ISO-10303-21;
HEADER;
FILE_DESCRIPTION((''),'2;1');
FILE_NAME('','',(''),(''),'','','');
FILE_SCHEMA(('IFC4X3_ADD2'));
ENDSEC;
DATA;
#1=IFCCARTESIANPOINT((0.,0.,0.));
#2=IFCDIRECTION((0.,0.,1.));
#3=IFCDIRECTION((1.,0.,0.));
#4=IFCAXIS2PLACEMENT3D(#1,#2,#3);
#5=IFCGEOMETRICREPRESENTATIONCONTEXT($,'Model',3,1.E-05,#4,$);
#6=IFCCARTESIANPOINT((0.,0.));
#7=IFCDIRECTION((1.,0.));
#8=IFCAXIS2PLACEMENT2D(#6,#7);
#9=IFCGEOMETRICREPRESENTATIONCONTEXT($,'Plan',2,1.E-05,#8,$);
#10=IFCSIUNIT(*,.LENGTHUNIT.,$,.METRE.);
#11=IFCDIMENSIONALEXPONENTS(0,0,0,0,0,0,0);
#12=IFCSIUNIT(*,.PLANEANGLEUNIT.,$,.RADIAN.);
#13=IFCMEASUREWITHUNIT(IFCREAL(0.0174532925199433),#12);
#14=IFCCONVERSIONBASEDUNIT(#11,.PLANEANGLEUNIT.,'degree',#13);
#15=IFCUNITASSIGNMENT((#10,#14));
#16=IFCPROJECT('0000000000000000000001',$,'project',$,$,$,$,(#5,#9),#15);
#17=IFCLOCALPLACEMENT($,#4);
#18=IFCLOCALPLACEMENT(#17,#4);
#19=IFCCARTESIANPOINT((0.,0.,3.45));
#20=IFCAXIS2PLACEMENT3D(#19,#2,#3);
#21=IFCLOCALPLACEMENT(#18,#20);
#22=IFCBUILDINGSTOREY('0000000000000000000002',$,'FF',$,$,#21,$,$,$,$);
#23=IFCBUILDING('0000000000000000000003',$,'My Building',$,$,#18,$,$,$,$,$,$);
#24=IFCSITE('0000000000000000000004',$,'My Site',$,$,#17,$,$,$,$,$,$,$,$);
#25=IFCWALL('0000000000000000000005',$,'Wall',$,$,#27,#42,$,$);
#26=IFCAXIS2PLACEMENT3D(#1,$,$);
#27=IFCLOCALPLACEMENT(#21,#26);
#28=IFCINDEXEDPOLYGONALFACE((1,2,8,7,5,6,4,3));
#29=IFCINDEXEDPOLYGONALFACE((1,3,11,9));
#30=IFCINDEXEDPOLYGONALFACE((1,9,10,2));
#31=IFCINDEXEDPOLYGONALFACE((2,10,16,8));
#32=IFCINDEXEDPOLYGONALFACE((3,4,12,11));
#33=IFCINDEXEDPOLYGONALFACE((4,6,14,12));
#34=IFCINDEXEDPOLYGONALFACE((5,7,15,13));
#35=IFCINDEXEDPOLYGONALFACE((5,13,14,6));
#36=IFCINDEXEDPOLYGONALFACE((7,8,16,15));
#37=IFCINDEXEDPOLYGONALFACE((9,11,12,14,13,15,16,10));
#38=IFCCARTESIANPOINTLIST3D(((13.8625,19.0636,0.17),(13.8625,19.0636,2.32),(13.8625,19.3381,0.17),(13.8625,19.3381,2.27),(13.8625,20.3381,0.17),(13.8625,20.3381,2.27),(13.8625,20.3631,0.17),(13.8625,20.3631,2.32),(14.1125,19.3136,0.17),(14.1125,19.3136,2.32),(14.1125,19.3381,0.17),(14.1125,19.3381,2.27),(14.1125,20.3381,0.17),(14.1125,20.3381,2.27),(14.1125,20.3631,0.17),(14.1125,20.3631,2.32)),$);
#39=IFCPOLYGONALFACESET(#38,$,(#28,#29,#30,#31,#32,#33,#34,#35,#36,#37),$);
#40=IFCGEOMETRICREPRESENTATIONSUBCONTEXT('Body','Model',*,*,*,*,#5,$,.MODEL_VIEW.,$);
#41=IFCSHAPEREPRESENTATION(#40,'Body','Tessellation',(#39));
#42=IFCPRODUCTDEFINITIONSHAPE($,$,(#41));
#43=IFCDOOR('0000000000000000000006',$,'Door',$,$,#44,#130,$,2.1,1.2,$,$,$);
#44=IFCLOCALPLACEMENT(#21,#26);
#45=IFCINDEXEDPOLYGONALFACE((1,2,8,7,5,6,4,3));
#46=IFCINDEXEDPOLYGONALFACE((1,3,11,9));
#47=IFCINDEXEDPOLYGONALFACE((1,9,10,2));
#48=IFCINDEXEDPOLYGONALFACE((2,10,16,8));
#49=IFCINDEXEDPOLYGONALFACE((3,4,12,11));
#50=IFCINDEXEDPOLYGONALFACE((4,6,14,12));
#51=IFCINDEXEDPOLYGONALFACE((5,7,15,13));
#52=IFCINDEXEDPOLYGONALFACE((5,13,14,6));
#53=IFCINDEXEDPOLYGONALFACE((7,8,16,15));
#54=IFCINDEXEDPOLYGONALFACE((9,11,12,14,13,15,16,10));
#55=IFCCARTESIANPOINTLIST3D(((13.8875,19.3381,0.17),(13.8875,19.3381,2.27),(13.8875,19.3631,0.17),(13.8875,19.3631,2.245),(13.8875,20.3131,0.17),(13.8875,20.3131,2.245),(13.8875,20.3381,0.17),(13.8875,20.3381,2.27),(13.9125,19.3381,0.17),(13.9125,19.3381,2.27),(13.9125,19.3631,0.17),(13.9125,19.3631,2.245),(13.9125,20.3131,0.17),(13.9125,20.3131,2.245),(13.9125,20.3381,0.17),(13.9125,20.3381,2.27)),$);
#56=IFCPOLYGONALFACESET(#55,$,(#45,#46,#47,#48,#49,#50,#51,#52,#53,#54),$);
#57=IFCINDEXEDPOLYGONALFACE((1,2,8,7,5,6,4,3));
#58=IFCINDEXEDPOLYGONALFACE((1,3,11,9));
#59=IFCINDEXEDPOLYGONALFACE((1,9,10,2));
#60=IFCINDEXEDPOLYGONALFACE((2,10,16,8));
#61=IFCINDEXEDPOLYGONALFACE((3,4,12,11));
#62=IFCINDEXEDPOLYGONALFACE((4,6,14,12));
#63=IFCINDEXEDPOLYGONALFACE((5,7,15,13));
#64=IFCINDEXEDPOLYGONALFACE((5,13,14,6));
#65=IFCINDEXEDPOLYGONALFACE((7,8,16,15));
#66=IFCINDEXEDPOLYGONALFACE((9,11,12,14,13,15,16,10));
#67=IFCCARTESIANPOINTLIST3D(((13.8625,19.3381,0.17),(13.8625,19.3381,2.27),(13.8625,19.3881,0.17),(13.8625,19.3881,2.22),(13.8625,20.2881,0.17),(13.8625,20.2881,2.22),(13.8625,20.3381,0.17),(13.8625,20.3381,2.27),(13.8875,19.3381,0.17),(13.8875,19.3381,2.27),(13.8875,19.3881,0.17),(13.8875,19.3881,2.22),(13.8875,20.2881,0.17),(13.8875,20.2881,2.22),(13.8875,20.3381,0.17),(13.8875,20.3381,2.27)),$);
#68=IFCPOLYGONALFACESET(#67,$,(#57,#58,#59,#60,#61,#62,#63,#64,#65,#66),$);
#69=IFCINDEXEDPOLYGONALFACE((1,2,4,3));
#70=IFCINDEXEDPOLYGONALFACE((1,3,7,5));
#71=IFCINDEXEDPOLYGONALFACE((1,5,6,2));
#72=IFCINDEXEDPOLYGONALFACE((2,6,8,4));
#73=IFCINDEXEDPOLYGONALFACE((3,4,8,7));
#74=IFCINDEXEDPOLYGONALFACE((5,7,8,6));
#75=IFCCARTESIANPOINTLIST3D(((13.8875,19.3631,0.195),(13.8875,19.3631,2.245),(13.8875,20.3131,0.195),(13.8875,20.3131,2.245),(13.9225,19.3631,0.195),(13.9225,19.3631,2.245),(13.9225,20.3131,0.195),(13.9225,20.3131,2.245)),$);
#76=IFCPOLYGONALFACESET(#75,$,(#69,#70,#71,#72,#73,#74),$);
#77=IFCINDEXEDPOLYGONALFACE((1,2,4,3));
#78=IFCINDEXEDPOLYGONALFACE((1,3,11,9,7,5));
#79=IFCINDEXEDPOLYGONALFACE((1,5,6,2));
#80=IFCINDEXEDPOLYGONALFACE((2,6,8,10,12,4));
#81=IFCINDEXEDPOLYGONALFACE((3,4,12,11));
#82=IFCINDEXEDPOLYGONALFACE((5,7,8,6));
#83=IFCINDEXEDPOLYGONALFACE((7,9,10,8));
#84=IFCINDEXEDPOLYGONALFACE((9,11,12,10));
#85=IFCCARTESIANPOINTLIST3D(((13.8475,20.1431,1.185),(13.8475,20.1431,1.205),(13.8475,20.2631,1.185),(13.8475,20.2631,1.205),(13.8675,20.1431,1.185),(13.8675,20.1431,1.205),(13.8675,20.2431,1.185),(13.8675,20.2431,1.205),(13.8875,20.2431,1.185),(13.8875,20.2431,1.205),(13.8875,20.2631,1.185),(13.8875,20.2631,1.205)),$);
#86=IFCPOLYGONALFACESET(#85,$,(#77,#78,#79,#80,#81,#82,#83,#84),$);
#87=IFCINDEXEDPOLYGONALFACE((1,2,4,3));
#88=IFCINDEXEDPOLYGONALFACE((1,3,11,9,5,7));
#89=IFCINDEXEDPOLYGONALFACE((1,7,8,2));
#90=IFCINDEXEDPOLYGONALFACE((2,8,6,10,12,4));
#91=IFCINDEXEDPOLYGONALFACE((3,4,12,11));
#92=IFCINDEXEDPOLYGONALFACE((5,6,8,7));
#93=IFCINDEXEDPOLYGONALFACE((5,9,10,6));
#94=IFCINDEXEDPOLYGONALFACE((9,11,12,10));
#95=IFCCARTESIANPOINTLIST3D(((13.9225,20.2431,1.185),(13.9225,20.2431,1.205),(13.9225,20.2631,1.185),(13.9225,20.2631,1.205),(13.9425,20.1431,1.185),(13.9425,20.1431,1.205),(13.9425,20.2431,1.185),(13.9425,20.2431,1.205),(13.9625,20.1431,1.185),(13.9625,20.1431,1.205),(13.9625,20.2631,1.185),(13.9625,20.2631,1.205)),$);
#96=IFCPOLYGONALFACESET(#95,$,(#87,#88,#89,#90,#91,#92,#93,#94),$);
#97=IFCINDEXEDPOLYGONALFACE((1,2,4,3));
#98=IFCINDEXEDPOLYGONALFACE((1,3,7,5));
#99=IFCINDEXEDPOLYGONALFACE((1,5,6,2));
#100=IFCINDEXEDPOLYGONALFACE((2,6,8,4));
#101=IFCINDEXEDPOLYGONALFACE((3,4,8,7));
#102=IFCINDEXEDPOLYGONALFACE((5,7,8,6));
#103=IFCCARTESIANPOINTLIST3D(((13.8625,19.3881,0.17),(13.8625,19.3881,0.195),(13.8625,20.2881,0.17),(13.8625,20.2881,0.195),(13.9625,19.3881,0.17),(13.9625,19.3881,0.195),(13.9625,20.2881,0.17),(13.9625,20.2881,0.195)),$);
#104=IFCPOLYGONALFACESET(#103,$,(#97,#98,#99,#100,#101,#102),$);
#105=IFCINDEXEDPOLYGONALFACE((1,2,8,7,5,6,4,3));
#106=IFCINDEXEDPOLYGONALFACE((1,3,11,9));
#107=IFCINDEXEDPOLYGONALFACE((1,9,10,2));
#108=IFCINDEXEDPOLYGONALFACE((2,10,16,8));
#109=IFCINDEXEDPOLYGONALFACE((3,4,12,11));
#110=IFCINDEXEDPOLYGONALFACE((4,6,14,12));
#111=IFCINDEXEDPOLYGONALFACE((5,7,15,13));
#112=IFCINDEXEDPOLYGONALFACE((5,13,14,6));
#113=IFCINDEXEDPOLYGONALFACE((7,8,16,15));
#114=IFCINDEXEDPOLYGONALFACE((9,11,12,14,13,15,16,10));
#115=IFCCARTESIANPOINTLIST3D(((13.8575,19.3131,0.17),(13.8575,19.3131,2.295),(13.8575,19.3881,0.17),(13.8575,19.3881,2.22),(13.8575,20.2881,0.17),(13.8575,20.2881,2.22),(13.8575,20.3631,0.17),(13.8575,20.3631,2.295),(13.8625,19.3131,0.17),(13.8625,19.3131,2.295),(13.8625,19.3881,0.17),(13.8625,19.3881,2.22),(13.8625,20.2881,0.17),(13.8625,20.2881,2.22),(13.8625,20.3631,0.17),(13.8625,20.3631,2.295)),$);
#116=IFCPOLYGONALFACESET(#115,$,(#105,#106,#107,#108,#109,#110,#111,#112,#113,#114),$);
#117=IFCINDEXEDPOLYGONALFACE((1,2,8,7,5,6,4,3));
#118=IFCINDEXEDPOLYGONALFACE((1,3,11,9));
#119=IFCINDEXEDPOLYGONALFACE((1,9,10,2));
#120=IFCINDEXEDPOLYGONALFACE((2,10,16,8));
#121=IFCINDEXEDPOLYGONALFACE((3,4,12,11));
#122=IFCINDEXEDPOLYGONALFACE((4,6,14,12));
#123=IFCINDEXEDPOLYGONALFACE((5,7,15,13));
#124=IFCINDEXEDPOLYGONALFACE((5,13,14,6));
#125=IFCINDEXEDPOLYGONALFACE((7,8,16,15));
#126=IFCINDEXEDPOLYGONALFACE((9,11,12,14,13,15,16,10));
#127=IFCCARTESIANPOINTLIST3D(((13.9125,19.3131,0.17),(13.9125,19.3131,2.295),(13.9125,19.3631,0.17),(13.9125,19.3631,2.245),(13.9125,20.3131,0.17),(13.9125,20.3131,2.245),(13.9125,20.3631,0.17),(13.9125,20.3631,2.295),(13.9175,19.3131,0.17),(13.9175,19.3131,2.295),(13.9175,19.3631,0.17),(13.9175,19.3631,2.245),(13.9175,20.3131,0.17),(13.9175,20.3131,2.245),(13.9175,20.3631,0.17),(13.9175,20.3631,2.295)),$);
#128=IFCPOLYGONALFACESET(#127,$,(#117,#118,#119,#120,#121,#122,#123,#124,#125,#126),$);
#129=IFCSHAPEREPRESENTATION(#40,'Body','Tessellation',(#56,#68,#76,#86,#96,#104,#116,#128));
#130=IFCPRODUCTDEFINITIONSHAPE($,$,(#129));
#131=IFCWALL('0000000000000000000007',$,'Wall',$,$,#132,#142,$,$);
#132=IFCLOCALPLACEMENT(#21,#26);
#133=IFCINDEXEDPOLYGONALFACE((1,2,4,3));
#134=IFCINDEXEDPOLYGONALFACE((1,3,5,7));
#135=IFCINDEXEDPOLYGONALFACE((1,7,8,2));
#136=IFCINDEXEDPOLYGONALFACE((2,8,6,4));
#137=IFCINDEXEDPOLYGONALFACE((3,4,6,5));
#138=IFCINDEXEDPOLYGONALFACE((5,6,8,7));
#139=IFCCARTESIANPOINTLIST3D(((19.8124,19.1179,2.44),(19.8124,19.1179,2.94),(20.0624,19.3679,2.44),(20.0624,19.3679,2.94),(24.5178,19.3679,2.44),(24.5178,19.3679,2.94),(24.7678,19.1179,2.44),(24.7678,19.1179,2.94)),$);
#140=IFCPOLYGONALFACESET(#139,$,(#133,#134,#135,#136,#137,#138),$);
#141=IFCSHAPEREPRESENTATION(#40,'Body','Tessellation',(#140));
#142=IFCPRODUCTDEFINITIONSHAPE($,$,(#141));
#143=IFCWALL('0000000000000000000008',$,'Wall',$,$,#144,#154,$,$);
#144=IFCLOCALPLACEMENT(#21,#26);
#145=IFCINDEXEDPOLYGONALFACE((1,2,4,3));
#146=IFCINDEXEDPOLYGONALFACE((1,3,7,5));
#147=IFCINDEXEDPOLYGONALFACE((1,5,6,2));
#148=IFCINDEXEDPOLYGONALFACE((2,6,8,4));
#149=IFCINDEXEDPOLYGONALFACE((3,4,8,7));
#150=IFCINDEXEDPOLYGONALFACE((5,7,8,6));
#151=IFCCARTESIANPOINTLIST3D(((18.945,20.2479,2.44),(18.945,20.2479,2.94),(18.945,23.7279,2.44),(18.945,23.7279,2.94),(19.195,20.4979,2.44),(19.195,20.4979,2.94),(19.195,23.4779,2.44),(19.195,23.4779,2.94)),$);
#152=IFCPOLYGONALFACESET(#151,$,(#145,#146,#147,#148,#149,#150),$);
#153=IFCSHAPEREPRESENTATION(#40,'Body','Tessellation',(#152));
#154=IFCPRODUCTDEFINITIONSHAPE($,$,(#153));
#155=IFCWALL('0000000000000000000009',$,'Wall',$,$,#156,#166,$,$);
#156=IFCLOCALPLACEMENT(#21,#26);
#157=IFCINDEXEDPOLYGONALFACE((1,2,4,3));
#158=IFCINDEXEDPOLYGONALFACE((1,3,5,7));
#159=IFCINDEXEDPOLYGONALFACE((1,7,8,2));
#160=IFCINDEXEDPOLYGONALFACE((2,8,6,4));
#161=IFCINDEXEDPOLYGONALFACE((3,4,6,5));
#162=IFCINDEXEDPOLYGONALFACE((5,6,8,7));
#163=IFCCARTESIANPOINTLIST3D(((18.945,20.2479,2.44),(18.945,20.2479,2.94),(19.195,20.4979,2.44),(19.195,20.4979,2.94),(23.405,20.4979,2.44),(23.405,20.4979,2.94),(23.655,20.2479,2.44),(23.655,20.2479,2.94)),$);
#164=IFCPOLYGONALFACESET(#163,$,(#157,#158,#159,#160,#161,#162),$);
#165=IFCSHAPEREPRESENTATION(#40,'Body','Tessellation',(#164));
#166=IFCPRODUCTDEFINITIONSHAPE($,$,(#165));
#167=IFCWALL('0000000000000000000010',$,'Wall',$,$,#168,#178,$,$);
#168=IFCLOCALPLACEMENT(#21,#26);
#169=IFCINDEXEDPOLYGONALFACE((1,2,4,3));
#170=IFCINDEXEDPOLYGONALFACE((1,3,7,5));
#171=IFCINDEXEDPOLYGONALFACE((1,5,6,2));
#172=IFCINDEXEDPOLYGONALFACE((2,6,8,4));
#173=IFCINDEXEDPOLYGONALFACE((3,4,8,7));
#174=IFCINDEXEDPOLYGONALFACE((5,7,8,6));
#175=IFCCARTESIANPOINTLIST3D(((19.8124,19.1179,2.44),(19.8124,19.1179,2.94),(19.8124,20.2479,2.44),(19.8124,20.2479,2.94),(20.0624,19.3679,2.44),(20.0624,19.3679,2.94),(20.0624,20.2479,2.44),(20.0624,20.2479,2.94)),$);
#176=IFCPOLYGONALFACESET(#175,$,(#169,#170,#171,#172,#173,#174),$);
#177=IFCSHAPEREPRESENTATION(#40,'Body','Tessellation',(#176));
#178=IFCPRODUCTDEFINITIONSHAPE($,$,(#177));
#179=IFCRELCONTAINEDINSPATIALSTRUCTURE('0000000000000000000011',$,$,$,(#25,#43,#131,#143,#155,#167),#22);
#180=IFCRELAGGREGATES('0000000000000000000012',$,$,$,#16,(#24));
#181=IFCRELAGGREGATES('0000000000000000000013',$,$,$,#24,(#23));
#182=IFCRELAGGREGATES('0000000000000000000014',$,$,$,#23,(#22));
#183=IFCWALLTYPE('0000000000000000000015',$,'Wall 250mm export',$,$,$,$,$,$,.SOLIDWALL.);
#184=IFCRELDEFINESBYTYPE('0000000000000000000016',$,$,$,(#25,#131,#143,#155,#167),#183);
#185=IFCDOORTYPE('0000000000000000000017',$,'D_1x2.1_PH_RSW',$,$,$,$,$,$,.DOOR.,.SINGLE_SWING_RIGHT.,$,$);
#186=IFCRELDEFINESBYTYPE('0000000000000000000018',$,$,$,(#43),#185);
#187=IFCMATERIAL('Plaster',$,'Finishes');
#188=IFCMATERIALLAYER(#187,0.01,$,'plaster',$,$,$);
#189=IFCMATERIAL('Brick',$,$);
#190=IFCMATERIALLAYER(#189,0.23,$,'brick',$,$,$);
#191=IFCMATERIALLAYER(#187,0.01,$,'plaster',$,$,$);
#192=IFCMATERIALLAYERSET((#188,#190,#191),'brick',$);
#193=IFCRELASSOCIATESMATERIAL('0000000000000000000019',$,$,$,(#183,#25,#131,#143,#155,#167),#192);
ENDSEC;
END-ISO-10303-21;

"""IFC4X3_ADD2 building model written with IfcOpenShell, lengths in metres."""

from ifc_helpers import new_model, entity, si_unit, converted_unit, frame, origin_with_axes, origin_2d_with_axis, place, context, subcontext, project, spatial, line, indexed_curve, outline, extrude, shape, source, transform, mapped, material, layer, layer_set, layer_usage, type_object, type_shapes, element, fill, save


model = new_model("IFC4X3_ADD2")

# Units and contexts
model_context = context("Model", 3, precision=1e-05, world=origin_with_axes())
plan_context = context("Plan", 2, precision=1e-05, world=origin_2d_with_axis())
body_context_1 = subcontext(model_context, "Body", "Model", "MODEL_VIEW")
body_context_2 = subcontext(plan_context, "Body", "Plan", "PLAN_VIEW")
ifc_project = project(units=[si_unit("LENGTHUNIT", "METRE"), converted_unit("PLANEANGLEUNIT", "degree", entity("IfcReal", 0.0174532925199433), si_unit("PLANEANGLEUNIT", "RADIAN"), dimensions=[0, 0, 0, 0, 0, 0, 0])], contexts=[model_context, plan_context])

# Site, building, storey
site_placement = place(None, origin_with_axes())
site = spatial("IfcSite", under=ifc_project, at=site_placement, Name="My Site")
building_placement = place(site_placement, origin_with_axes())
building = spatial("IfcBuilding", under=site, at=building_placement, Name="My Building")
storey_placement = place(building_placement, frame((0.0, 0.0, 3.45), z_axis=(0.0, 0.0, 1.0), x_axis=(1.0, 0.0, 0.0)))
storey = spatial("IfcBuildingStorey", under=building, at=storey_placement, Name="FF")

# Shared definitions
ifc_material_1 = material(Name="Plaster", Category="Finishes")
ifc_layer_1 = layer(ifc_material_1, 0.01, Name="plaster")
ifc_material_2 = material(Name="Brick")
ifc_layer_2 = layer(ifc_material_2, 0.23, Name="brick")
ifc_layer_3 = layer(ifc_material_1, 0.01, Name="plaster")
ifc_layer_set_1 = layer_set([ifc_layer_1, ifc_layer_2, ifc_layer_3], Name="brick")
wall_type_1 = type_object("IfcWallType", Name="Wall 250mm export", PredefinedType="SOLIDWALL", material=ifc_layer_set_1)

# Shared definitions
shared_shape_1 = source(origin_with_axes(), body_context_1, "Body", "SweptSolid", [
    extrude(outline(indexed_curve([(0.0, 0.0), (1.0, 0.0), (1.0, 2.1), (0.0, 2.1)], segments=[line(1, 2, 3, 4, 1)])), frame((0.0, -0.6, 0.0), z_axis=(0.0, -1.0, 0.0), x_axis=(1.0, 0.0, 0.0)), (0.0, 0.0, -1.0), 1.2),
])
door_type_1 = type_object("IfcDoorType", Name="D_1x2.1_PH_RSW", OperationType="SINGLE_SWING_RIGHT", PredefinedType="DOOR")
shared_shape_2 = source(origin_with_axes(), body_context_1, "Body", "SweptSolid", [
    extrude(outline(indexed_curve([(0.0, 0.0), (0.0, 2.1), (1.0, 2.1), (1.0, 0.0), (0.975, 0.0), (0.975, 2.075), (0.025, 2.075), (0.025, 0.0)], segments=[line(1, 2, 3, 4, 5, 6, 7, 8, 1)])), frame((0.0, 0.025, 0.0), z_axis=(0.0, -1.0, 0.0), x_axis=(1.0, 0.0, 0.0)), (0.0, 0.0, -1.0), 0.025),
    extrude(outline(indexed_curve([(0.0, 0.0), (0.0, 2.1), (1.0, 2.1), (1.0, 0.0), (0.95, 0.0), (0.95, 2.05), (0.05, 2.05), (0.05, 0.0)], segments=[line(1, 2, 3, 4, 5, 6, 7, 8, 1)])), frame((0.0, 0.0, 0.0), z_axis=(0.0, -1.0, 0.0), x_axis=(1.0, 0.0, 0.0)), (0.0, 0.0, -1.0), 0.025),
    extrude(outline(indexed_curve([(0.0, 0.0), (0.95, 0.0), (0.95, 0.035), (0.0, 0.035)], segments=[line(1, 2, 3, 4, 1)])), frame((0.025, 0.025, 0.025), z_axis=(0.0, 0.0, 1.0), x_axis=(1.0, 0.0, 0.0)), (0.0, 0.0, 1.0), 2.05),
    extrude(outline(indexed_curve([(0.0, 0.0), (0.0, -0.04), (0.12, -0.04), (0.12, -0.02), (0.02, -0.02), (0.02, 0.0)], segments=[line(1, 2, 3, 4, 5, 6, 1)])), frame((0.075, 0.025, 1.015), z_axis=(0.0, 0.0, 1.0), x_axis=(1.0, 0.0, 0.0)), (0.0, 0.0, 1.0), 0.02),
    extrude(outline(indexed_curve([(0.0, 0.0), (0.0, 0.04), (0.12, 0.04), (0.12, 0.02), (0.02, 0.02), (0.02, 0.0)], segments=[line(1, 2, 3, 4, 5, 6, 1)])), frame((0.075, 0.06, 1.015), z_axis=(0.0, 0.0, 1.0), x_axis=(1.0, 0.0, 0.0)), (0.0, 0.0, 1.0), 0.02),
    extrude(outline(indexed_curve([(0.0, 0.0), (0.9, 0.0), (0.9, 0.1), (0.0, 0.1)], segments=[line(1, 2, 3, 4, 1)])), frame((0.05, 0.0, 0.0), z_axis=(0.0, 0.0, 1.0), x_axis=(1.0, 0.0, 0.0)), (0.0, 0.0, 1.0), 0.025),
    extrude(outline(indexed_curve([(0.0, 0.0), (0.0, 2.125), (1.05, 2.125), (1.05, 0.0), (0.975, 0.0), (0.975, 2.05), (0.075, 2.05), (0.075, 0.0)], segments=[line(1, 2, 3, 4, 5, 6, 7, 8, 1)])), frame((-0.025, -0.005, 0.0), z_axis=(0.0, -1.0, 0.0), x_axis=(1.0, 0.0, 0.0)), (0.0, 0.0, -1.0), 0.005),
    extrude(outline(indexed_curve([(0.0, 0.0), (0.0, 2.125), (1.05, 2.125), (1.05, 0.0), (1.0, 0.0), (1.0, 2.075), (0.05, 2.075), (0.05, 0.0)], segments=[line(1, 2, 3, 4, 5, 6, 7, 8, 1)])), frame((-0.025, 0.05, 0.0), z_axis=(0.0, -1.0, 0.0), x_axis=(1.0, 0.0, 0.0)), (0.0, 0.0, -1.0), 0.005),
])
shared_shape_3 = source(origin_with_axes(), body_context_2, "Body", "Curve2D", [
    entity("IfcIndexedPolyCurve", entity("IfcCartesianPointList2D", [[0.0, 0.0], [0.0, 0.05], [0.025, 0.05], [0.025, 0.025], [0.05, 0.025], [0.05, 0.0]]), [entity("IfcLineIndex", [1, 2, 3, 4, 5, 6, 1])]),
    entity("IfcIndexedPolyCurve", entity("IfcCartesianPointList2D", [[1.0, 0.0], [1.0, 0.05], [0.975, 0.05], [0.975, 0.025], [0.95, 0.025], [0.95, 0.0]]), [entity("IfcLineIndex", [1, 2, 3, 4, 5, 6, 1])]),
    entity("IfcTrimmedCurve", entity("IfcEllipse", entity("IfcAxis2Placement2D", entity("IfcCartesianPoint", [0.94, 0.05]), entity("IfcDirection", [1.0, 0.0])), 0.915, 0.95), [entity("IfcCartesianPoint", [0.94, 1.0])], [entity("IfcCartesianPoint", [0.025, 0.05])], True, "CARTESIAN"),
    entity("IfcIndexedPolyCurve", entity("IfcCartesianPointList2D", [[0.975, 0.05], [0.94, 0.05], [0.94, 1.0], [0.975, 1.0]]), [entity("IfcLineIndex", [1, 2, 3, 4, 1])]),
])
type_shapes(door_type_1, [shared_shape_2, shared_shape_3])

# Wall, opening, door
ifc_layer_usage_1 = layer_usage(ifc_layer_set_1, "AXIS2", "POSITIVE", 0.0)
wall_1_placement = place(storey_placement, frame((13.8625, 20.3631, 0.17), z_axis=(0.0, 0.0, 1.0), x_axis=(-0.000001, -1.0, 0.0)))
wall_1 = element("IfcWall", 1, at=wall_1_placement, inside=storey, type_object=wall_type_1, material=ifc_layer_usage_1, Name="Wall", context=body_context_1, shape_type="SweptSolid", body=[
    extrude(outline(indexed_curve([(0.0, 0.0), (0.0, 0.25), (1.0495, 0.25), (1.2995, 0.0)], segments=[line(1, 2, 3, 4, 1)])), origin_with_axes(), (0.0, 0.0, 1.0), 2.15),
])
opening_1_placement = place(wall_1_placement, frame((0.025, 0.0, 0.0), z_axis=(0.0, 0.0, 1.0), x_axis=(1.0, 0.0, 0.0)))
opening_1 = element("IfcOpeningElement", 2, at=opening_1_placement, cuts=wall_1, PredefinedType="OPENING", context=body_context_1, shape_type="MappedRepresentation", body=[
    mapped(shared_shape_1, transform((0.0, 0.0, 0.0), x_axis=(1.0, 0.0, 0.0), y_axis=(0.0, 1.0, 0.0), z_axis=(0.0, 0.0, 1.0), scale=1.0)),
])
door_1_placement = place(opening_1_placement, frame((0.0, 0.0, 0.0), z_axis=(0.0, 0.0, 1.0), x_axis=(1.0, 0.0, 0.0)))
door_1 = element("IfcDoor", 3, at=door_1_placement, inside=storey, type_object=door_type_1, Name="Door", OverallHeight=2.1, OverallWidth=1.2, shapes=[
    shape(body_context_1, "Body", "MappedRepresentation", [mapped(shared_shape_2, transform((0.0, 0.0, 0.0), x_axis=(1.0, 0.0, 0.0), y_axis=(0.0, 1.0, 0.0), z_axis=(0.0, 0.0, 1.0), scale=1.0))]),
    shape(body_context_2, "Body", "MappedRepresentation", [mapped(shared_shape_3, transform((0.0, 0.0, 0.0), x_axis=(1.0, 0.0, 0.0), y_axis=(0.0, 1.0, 0.0), z_axis=(0.0, 0.0, 1.0), scale=1.0))]),
])
fill(opening_1, door_1)

# Walls
ifc_layer_usage_2 = layer_usage(ifc_layer_set_1, "AXIS2", "POSITIVE", 0.0)
wall_2_placement = place(storey_placement, frame((20.0624, 19.1179, 2.44), z_axis=(0.0, 0.0, 1.0), x_axis=(1.0, 0.0, 0.0)))
element("IfcWall", 4, at=wall_2_placement, inside=storey, type_object=wall_type_1, material=ifc_layer_usage_2, Name="Wall", context=body_context_1, shape_type="SweptSolid", body=[
    extrude(outline(indexed_curve([(-0.25, 0.0), (0.0, 0.25), (4.4554, 0.25), (4.7054, 0.0)], segments=[line(1, 2, 3, 4, 1)])), origin_with_axes(), (0.0, 0.0, 1.0), 0.5),
])
ifc_layer_usage_3 = layer_usage(ifc_layer_set_1, "AXIS2", "POSITIVE", 0.0)
wall_3_placement = place(storey_placement, frame((19.195, 20.2479, 2.44), z_axis=(0.0, 0.0, 1.0), x_axis=(0.0, 1.0, 0.0)))
element("IfcWall", 5, at=wall_3_placement, inside=storey, type_object=wall_type_1, material=ifc_layer_usage_3, Name="Wall", context=body_context_1, shape_type="SweptSolid", body=[
    extrude(outline(indexed_curve([(0.25, 0.0), (0.0, 0.25), (3.48, 0.25), (3.23, 0.0)], segments=[line(1, 2, 3, 4, 1)])), origin_with_axes(), (0.0, 0.0, 1.0), 0.5),
])
ifc_layer_usage_4 = layer_usage(ifc_layer_set_1, "AXIS2", "POSITIVE", 0.0)
wall_4_placement = place(storey_placement, frame((19.195, 20.2479, 2.44), z_axis=(0.0, 0.0, 1.0), x_axis=(1.0, 0.0, 0.0)))
element("IfcWall", 6, at=wall_4_placement, inside=storey, type_object=wall_type_1, material=ifc_layer_usage_4, Name="Wall", context=body_context_1, shape_type="SweptSolid", body=[
    extrude(outline(indexed_curve([(-0.25, 0.0), (0.0, 0.25), (4.21, 0.25), (4.46, 0.0)], segments=[line(1, 2, 3, 4, 1)])), origin_with_axes(), (0.0, 0.0, 1.0), 0.5),
])
ifc_layer_usage_5 = layer_usage(ifc_layer_set_1, "AXIS2", "POSITIVE", 0.0)
wall_5_placement = place(storey_placement, frame((20.0624, 19.1179, 2.44), z_axis=(0.0, 0.0, 1.0), x_axis=(0.0, 1.0, 0.0)))
element("IfcWall", 7, at=wall_5_placement, inside=storey, type_object=wall_type_1, material=ifc_layer_usage_5, Name="Wall", context=body_context_1, shape_type="SweptSolid", body=[
    extrude(outline(indexed_curve([(0.25, 0.0), (0.0, 0.25), (1.13, 0.25), (1.13, 0.0)], segments=[line(1, 2, 3, 4, 1)])), origin_with_axes(), (0.0, 0.0, 1.0), 0.5),
])

save(model, "model.ifc")
